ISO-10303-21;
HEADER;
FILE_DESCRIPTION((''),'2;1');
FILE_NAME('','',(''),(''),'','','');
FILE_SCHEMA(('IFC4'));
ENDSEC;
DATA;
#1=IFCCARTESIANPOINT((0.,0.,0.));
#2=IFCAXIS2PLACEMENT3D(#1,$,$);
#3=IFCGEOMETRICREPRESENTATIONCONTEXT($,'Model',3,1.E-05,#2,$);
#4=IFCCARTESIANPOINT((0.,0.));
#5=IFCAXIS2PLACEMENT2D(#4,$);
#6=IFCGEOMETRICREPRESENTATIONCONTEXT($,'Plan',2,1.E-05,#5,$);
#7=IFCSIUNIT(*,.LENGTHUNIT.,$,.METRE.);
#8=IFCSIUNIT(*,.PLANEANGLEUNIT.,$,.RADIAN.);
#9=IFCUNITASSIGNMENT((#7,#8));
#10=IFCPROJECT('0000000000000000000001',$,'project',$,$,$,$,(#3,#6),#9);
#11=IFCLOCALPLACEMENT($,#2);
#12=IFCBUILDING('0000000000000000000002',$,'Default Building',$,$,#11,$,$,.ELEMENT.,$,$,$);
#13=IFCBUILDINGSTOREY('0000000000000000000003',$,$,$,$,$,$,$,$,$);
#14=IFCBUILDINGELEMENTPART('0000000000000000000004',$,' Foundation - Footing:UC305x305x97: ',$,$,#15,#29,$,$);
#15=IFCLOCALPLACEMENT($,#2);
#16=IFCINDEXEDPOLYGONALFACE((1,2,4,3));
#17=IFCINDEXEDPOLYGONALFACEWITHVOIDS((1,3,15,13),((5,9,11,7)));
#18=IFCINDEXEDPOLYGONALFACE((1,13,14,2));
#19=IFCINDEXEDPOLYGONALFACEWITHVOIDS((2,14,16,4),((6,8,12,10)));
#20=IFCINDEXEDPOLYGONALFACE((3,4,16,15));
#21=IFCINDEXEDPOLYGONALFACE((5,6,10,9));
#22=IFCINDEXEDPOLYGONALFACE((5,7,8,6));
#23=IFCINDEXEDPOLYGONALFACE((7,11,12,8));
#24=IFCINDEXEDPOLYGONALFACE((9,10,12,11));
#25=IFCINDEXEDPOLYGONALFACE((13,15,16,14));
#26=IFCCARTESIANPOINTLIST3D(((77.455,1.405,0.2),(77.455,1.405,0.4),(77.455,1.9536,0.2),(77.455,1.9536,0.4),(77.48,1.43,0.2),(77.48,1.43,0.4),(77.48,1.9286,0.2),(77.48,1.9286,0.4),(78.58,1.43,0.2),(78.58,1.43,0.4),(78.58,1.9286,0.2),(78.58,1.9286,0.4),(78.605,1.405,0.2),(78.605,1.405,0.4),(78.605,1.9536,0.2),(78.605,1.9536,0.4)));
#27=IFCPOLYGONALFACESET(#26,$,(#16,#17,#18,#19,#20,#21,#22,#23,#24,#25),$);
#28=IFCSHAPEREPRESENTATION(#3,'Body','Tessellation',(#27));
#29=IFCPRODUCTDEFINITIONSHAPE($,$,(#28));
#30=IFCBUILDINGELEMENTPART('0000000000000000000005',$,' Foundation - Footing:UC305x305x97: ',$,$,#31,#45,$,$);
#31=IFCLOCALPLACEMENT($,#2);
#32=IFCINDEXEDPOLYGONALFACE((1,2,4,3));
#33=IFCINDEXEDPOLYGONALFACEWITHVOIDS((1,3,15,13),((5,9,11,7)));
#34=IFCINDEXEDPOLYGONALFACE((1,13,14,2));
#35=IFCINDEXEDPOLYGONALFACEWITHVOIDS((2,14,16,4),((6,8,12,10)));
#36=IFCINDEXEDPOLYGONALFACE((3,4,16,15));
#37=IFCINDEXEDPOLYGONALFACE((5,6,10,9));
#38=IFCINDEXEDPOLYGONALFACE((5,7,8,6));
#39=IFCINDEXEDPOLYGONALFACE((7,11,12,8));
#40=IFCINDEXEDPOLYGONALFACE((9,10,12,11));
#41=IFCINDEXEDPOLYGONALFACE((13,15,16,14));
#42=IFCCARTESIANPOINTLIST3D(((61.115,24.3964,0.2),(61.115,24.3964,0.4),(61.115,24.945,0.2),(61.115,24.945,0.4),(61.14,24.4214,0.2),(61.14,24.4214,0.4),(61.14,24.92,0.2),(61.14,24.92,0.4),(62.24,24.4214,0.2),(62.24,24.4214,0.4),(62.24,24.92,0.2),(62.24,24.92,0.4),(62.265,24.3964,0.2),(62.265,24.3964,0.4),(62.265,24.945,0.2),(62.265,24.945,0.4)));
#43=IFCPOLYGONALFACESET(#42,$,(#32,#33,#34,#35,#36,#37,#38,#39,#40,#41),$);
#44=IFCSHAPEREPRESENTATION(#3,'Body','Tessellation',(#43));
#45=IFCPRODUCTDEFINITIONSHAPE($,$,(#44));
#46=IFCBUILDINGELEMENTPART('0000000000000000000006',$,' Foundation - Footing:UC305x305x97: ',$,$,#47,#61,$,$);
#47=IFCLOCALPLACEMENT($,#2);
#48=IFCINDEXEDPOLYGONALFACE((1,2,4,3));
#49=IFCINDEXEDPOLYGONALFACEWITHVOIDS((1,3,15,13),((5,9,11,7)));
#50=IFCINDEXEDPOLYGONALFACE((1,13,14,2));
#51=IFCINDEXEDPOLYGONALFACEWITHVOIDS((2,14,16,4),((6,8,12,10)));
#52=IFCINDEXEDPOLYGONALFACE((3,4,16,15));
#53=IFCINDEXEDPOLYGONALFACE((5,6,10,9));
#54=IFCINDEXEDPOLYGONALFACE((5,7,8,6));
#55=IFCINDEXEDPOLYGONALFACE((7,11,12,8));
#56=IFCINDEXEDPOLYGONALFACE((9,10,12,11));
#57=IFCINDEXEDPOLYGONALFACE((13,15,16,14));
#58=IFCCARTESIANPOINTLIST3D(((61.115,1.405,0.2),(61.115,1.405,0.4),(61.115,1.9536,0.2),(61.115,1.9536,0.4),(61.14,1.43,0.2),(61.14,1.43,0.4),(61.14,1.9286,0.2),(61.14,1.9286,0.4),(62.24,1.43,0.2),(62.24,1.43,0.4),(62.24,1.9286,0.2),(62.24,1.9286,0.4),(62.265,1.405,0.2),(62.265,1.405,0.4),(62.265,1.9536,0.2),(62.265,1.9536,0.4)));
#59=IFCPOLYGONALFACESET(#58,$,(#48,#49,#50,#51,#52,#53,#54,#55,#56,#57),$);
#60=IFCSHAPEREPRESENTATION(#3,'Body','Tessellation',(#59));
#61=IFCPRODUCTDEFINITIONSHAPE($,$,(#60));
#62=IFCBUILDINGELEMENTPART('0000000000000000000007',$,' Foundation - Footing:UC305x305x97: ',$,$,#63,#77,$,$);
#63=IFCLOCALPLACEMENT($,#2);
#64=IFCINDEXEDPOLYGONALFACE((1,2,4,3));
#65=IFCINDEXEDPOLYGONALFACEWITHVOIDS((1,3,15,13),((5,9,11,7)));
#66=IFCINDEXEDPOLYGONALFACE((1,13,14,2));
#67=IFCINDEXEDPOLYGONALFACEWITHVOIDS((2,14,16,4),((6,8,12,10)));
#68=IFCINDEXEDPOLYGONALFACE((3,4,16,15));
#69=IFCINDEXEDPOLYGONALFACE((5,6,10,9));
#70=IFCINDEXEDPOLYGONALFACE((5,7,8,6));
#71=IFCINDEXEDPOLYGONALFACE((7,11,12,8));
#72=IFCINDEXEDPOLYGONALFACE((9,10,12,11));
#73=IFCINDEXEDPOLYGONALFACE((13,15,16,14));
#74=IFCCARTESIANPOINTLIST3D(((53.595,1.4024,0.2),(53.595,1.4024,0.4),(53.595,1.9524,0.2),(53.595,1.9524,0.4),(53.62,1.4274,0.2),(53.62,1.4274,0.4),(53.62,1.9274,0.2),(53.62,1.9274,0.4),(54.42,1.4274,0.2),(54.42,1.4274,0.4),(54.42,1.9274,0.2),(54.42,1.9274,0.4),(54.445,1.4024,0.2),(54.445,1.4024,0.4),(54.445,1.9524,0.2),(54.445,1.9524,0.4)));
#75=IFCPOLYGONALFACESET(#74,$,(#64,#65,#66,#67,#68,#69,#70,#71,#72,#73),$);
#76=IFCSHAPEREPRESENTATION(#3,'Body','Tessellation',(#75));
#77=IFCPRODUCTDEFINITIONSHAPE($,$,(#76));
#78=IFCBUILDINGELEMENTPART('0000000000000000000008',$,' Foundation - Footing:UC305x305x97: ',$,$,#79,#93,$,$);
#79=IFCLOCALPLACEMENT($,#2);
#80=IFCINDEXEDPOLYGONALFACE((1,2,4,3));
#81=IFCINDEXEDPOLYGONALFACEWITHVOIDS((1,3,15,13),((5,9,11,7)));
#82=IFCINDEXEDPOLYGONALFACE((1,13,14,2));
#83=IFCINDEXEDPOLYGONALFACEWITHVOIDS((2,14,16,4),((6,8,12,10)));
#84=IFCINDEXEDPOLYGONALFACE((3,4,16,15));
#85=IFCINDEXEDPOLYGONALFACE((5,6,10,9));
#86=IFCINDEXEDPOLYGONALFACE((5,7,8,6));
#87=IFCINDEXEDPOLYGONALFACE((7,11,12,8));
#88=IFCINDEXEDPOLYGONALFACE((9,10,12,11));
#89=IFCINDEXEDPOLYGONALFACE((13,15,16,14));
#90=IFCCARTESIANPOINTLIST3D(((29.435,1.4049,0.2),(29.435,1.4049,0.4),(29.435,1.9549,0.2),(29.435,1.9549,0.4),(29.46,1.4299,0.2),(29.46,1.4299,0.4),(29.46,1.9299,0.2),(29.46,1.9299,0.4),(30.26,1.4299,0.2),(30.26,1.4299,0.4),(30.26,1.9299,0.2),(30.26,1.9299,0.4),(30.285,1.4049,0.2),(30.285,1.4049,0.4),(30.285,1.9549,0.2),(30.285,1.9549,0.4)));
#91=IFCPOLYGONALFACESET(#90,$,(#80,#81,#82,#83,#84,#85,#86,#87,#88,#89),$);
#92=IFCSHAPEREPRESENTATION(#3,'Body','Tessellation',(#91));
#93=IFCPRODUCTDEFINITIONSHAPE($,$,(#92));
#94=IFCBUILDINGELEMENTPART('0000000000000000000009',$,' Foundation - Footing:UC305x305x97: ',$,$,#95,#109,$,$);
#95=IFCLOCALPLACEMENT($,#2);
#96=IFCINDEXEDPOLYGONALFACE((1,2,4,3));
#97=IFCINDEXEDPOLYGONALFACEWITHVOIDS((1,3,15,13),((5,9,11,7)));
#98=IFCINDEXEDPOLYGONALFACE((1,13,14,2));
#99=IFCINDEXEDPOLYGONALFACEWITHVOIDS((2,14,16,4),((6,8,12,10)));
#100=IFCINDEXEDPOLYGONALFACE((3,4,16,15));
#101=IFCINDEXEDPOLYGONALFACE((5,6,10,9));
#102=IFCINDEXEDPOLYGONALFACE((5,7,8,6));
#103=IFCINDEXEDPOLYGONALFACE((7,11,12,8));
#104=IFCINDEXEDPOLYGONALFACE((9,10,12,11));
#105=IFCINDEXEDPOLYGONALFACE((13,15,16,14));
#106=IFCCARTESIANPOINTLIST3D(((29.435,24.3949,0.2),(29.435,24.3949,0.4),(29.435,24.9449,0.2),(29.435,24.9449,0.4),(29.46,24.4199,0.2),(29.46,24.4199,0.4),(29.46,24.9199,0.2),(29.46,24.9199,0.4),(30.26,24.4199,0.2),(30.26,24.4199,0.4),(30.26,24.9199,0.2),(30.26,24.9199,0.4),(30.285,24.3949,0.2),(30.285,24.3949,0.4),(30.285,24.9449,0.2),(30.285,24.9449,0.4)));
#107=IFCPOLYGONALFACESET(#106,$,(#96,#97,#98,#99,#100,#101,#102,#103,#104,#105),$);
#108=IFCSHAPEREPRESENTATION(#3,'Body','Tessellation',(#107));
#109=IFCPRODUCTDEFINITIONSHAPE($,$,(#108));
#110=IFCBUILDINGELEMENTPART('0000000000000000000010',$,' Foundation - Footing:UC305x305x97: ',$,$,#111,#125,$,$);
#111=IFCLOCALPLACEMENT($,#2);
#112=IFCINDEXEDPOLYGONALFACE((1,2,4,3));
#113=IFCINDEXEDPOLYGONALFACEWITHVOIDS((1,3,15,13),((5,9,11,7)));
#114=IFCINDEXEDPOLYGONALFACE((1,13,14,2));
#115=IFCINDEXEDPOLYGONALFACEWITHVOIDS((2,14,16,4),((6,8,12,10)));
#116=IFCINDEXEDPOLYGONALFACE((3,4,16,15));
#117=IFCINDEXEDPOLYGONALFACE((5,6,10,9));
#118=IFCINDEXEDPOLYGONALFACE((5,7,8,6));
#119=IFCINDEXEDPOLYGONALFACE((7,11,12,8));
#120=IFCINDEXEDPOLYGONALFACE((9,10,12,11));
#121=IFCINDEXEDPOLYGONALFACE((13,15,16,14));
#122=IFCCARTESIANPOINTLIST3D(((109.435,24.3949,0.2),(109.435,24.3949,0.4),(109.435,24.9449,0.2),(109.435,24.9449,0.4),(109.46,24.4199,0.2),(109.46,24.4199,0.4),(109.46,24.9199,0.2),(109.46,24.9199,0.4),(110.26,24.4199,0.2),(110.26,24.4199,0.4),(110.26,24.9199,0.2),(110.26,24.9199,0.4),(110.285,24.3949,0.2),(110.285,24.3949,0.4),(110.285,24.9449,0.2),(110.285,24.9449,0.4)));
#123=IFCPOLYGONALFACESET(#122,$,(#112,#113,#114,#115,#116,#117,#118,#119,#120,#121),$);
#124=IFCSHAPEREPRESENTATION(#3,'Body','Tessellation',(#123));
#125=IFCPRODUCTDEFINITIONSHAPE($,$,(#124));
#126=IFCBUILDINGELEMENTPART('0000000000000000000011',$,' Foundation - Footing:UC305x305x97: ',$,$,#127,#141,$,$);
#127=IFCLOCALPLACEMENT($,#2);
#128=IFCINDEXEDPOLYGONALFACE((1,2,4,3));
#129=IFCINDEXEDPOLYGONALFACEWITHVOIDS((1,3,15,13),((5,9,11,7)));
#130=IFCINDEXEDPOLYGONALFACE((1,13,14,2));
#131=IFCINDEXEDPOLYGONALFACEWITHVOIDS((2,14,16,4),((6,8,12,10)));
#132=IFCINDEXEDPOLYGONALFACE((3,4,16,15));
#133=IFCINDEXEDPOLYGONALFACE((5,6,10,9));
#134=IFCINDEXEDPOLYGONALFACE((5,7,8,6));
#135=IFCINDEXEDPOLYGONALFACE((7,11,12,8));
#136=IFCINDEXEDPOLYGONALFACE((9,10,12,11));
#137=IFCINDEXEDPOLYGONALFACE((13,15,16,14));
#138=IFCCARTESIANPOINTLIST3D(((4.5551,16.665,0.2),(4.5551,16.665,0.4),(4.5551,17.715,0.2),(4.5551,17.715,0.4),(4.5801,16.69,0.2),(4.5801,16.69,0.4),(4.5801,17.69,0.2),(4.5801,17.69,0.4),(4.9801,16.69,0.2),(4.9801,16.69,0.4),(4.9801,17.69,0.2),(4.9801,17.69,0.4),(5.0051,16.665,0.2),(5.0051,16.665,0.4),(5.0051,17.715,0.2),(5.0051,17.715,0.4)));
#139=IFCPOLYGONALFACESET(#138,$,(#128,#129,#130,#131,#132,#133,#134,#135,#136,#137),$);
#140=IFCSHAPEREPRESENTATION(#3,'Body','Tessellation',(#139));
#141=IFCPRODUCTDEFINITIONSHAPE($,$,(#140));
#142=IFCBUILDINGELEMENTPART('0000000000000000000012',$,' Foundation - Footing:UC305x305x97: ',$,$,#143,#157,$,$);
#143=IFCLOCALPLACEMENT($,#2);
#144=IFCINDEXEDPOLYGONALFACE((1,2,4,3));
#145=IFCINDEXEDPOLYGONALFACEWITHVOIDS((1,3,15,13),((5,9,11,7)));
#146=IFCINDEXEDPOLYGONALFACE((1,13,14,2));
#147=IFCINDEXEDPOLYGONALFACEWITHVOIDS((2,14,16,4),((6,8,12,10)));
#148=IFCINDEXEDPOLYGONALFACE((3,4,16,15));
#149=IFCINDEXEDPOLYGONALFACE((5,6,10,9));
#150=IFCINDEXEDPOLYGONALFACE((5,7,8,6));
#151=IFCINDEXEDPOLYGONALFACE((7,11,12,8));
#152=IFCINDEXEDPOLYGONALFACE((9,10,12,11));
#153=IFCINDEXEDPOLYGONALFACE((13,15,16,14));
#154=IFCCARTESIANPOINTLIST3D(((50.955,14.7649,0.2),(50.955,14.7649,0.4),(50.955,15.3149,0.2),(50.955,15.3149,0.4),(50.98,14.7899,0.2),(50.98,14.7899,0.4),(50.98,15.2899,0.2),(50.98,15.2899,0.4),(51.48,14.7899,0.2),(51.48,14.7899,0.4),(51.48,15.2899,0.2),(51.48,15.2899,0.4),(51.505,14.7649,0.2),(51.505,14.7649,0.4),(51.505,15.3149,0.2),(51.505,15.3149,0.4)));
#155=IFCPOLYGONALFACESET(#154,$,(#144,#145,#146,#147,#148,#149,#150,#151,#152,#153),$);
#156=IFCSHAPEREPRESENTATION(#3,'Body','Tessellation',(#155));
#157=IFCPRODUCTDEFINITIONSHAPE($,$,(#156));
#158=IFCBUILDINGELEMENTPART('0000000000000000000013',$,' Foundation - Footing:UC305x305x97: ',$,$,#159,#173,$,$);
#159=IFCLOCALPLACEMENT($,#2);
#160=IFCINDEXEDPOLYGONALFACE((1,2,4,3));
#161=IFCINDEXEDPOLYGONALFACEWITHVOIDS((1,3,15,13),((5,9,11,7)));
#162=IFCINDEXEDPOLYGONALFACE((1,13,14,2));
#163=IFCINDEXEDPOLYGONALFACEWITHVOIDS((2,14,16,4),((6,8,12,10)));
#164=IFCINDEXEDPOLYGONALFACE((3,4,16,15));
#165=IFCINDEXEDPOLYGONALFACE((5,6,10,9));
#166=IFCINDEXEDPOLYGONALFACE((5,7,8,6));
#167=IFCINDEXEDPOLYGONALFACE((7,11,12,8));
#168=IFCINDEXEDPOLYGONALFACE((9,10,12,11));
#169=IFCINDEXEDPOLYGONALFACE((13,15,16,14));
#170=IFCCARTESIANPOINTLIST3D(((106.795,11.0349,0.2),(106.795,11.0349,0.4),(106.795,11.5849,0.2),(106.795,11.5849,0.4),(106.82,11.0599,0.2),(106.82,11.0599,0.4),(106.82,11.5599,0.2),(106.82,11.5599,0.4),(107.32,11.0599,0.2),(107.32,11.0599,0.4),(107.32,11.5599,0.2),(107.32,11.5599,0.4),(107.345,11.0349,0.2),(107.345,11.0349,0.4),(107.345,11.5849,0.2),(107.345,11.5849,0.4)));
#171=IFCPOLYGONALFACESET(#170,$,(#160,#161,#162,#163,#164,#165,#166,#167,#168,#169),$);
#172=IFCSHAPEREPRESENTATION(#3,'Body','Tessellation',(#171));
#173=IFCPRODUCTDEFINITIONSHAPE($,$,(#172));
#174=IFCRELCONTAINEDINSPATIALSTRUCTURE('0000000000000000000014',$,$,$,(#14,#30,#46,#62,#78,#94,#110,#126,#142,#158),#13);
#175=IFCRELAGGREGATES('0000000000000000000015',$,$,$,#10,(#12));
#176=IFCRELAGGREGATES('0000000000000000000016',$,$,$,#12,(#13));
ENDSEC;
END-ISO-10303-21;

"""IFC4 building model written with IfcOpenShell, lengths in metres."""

from ifc_helpers import new_model, si_unit, origin, origin_2d, place, context, project, spatial, polyline, outline, extrude, element, save


model = new_model("IFC4")

# Units and contexts
model_context = context("Model", 3, precision=1e-05, world=origin())
plan_context = context("Plan", 2, precision=1e-05, world=origin_2d())
ifc_project = project(units=[si_unit("LENGTHUNIT", "METRE"), si_unit("PLANEANGLEUNIT", "RADIAN")], contexts=[model_context, plan_context])

# Building, storey
building_placement = place(None, origin())
building = spatial("IfcBuilding", under=ifc_project, at=building_placement, Name="Default Building", CompositionType="ELEMENT")
storey = spatial("IfcBuildingStorey", under=building)

# Building element parts, openings
building_element_part_1 = element("IfcBuildingElementPart", 1, inside=storey, Name=" Foundation - Footing:UC305x305x97: ", context=model_context, shape_type="SweptSolid", body=[
    extrude(outline(polyline([(77.455, 1.405, 0.2), (78.605, 1.405, 0.2), (78.605, 1.9536, 0.2), (77.455, 1.9536, 0.2), (77.455, 1.405, 0.2)])), None, (0.0, 0.0, 1.0), 0.2),
])
element("IfcOpeningElement", 2, inside=storey, cuts=building_element_part_1, context=model_context, shape_type="SweptSolid", body=[
    extrude(outline(polyline([(77.48, 1.43, 0.2), (78.58, 1.43, 0.2), (78.58, 1.9286, 0.2), (77.48, 1.9286, 0.2), (77.48, 1.43, 0.2)])), None, (0.0, 0.0, 1.0), 0.2),
])
building_element_part_2 = element("IfcBuildingElementPart", 3, inside=storey, Name=" Foundation - Footing:UC305x305x97: ", context=model_context, shape_type="SweptSolid", body=[
    extrude(outline(polyline([(61.115, 24.3964, 0.2), (62.265, 24.3964, 0.2), (62.265, 24.945, 0.2), (61.115, 24.945, 0.2), (61.115, 24.3964, 0.2)])), None, (0.0, 0.0, 1.0), 0.2),
])
element("IfcOpeningElement", 4, inside=storey, cuts=building_element_part_2, context=model_context, shape_type="SweptSolid", body=[
    extrude(outline(polyline([(61.14, 24.4214, 0.2), (62.24, 24.4214, 0.2), (62.24, 24.92, 0.2), (61.14, 24.92, 0.2), (61.14, 24.4214, 0.2)])), None, (0.0, 0.0, 1.0), 0.2),
])
building_element_part_3 = element("IfcBuildingElementPart", 5, inside=storey, Name=" Foundation - Footing:UC305x305x97: ", context=model_context, shape_type="SweptSolid", body=[
    extrude(outline(polyline([(61.115, 1.405, 0.2), (62.265, 1.405, 0.2), (62.265, 1.9536, 0.2), (61.115, 1.9536, 0.2), (61.115, 1.405, 0.2)])), None, (0.0, 0.0, 1.0), 0.2),
])
element("IfcOpeningElement", 6, inside=storey, cuts=building_element_part_3, context=model_context, shape_type="SweptSolid", body=[
    extrude(outline(polyline([(61.14, 1.43, 0.2), (62.24, 1.43, 0.2), (62.24, 1.9286, 0.2), (61.14, 1.9286, 0.2), (61.14, 1.43, 0.2)])), None, (0.0, 0.0, 1.0), 0.2),
])
building_element_part_4 = element("IfcBuildingElementPart", 7, inside=storey, Name=" Foundation - Footing:UC305x305x97: ", context=model_context, shape_type="SweptSolid", body=[
    extrude(outline(polyline([(54.445, 1.4024, 0.2), (53.595, 1.4024, 0.2), (53.595, 1.9524, 0.2), (54.445, 1.9524, 0.2), (54.445, 1.4024, 0.2)])), None, (0.0, 0.0, 1.0), 0.2),
])
element("IfcOpeningElement", 8, inside=storey, cuts=building_element_part_4, context=model_context, shape_type="SweptSolid", body=[
    extrude(outline(polyline([(54.42, 1.4274, 0.2), (53.62, 1.4274, 0.2), (53.62, 1.9274, 0.2), (54.42, 1.9274, 0.2), (54.42, 1.4274, 0.2)])), None, (0.0, 0.0, 1.0), 0.2),
])
building_element_part_5 = element("IfcBuildingElementPart", 9, inside=storey, Name=" Foundation - Footing:UC305x305x97: ", context=model_context, shape_type="SweptSolid", body=[
    extrude(outline(polyline([(30.285, 1.4049, 0.2), (29.435, 1.4049, 0.2), (29.435, 1.9549, 0.2), (30.285, 1.9549, 0.2), (30.285, 1.4049, 0.2)])), None, (0.0, 0.0, 1.0), 0.2),
])
element("IfcOpeningElement", 10, inside=storey, cuts=building_element_part_5, context=model_context, shape_type="SweptSolid", body=[
    extrude(outline(polyline([(30.26, 1.4299, 0.2), (29.46, 1.4299, 0.2), (29.46, 1.9299, 0.2), (30.26, 1.9299, 0.2), (30.26, 1.4299, 0.2)])), None, (0.0, 0.0, 1.0), 0.2),
])
building_element_part_6 = element("IfcBuildingElementPart", 11, inside=storey, Name=" Foundation - Footing:UC305x305x97: ", context=model_context, shape_type="SweptSolid", body=[
    extrude(outline(polyline([(30.285, 24.3949, 0.2), (29.435, 24.3949, 0.2), (29.435, 24.9449, 0.2), (30.285, 24.9449, 0.2), (30.285, 24.3949, 0.2)])), None, (0.0, 0.0, 1.0), 0.2),
])
element("IfcOpeningElement", 12, inside=storey, cuts=building_element_part_6, context=model_context, shape_type="SweptSolid", body=[
    extrude(outline(polyline([(30.26, 24.4199, 0.2), (29.46, 24.4199, 0.2), (29.46, 24.9199, 0.2), (30.26, 24.9199, 0.2), (30.26, 24.4199, 0.2)])), None, (0.0, 0.0, 1.0), 0.2),
])
building_element_part_7 = element("IfcBuildingElementPart", 13, inside=storey, Name=" Foundation - Footing:UC305x305x97: ", context=model_context, shape_type="SweptSolid", body=[
    extrude(outline(polyline([(110.285, 24.3949, 0.2), (109.435, 24.3949, 0.2), (109.435, 24.9449, 0.2), (110.285, 24.9449, 0.2), (110.285, 24.3949, 0.2)])), None, (0.0, 0.0, 1.0), 0.2),
])
element("IfcOpeningElement", 14, inside=storey, cuts=building_element_part_7, context=model_context, shape_type="SweptSolid", body=[
    extrude(outline(polyline([(110.26, 24.4199, 0.2), (109.46, 24.4199, 0.2), (109.46, 24.9199, 0.2), (110.26, 24.9199, 0.2), (110.26, 24.4199, 0.2)])), None, (0.0, 0.0, 1.0), 0.2),
])
building_element_part_8 = element("IfcBuildingElementPart", 15, inside=storey, Name=" Foundation - Footing:UC305x305x97: ", context=model_context, shape_type="SweptSolid", body=[
    extrude(outline(polyline([(4.5551, 17.715, 0.2), (5.0051, 17.715, 0.2), (5.0051, 16.665, 0.2), (4.5551, 16.665, 0.2), (4.5551, 17.715, 0.2)])), None, (0.0, 0.0, 1.0), 0.2),
])
element("IfcOpeningElement", 16, inside=storey, cuts=building_element_part_8, context=model_context, shape_type="SweptSolid", body=[
    extrude(outline(polyline([(4.5801, 17.69, 0.2), (4.9801, 17.69, 0.2), (4.9801, 16.69, 0.2), (4.5801, 16.69, 0.2), (4.5801, 17.69, 0.2)])), None, (0.0, 0.0, 1.0), 0.2),
])
building_element_part_9 = element("IfcBuildingElementPart", 17, inside=storey, Name=" Foundation - Footing:UC305x305x97: ", context=model_context, shape_type="SweptSolid", body=[
    extrude(outline(polyline([(50.955, 15.3149, 0.2), (51.505, 15.3149, 0.2), (51.505, 14.7649, 0.2), (50.955, 14.7649, 0.2), (50.955, 15.3149, 0.2)])), None, (0.0, 0.0, 1.0), 0.2),
])
element("IfcOpeningElement", 18, inside=storey, cuts=building_element_part_9, context=model_context, shape_type="SweptSolid", body=[
    extrude(outline(polyline([(50.98, 15.2899, 0.2), (51.48, 15.2899, 0.2), (51.48, 14.7899, 0.2), (50.98, 14.7899, 0.2), (50.98, 15.2899, 0.2)])), None, (0.0, 0.0, 1.0), 0.2),
])
building_element_part_10 = element("IfcBuildingElementPart", 19, inside=storey, Name=" Foundation - Footing:UC305x305x97: ", context=model_context, shape_type="SweptSolid", body=[
    extrude(outline(polyline([(106.795, 11.0349, 0.2), (107.345, 11.0349, 0.2), (107.345, 11.5849, 0.2), (106.795, 11.5849, 0.2), (106.795, 11.0349, 0.2)])), None, (0.0, 0.0, 1.0), 0.2),
])
element("IfcOpeningElement", 20, inside=storey, cuts=building_element_part_10, context=model_context, shape_type="SweptSolid", body=[
    extrude(outline(polyline([(106.82, 11.0599, 0.2), (107.32, 11.0599, 0.2), (107.32, 11.5599, 0.2), (106.82, 11.5599, 0.2), (106.82, 11.0599, 0.2)])), None, (0.0, 0.0, 1.0), 0.2),
])

save(model, "model.ifc")
